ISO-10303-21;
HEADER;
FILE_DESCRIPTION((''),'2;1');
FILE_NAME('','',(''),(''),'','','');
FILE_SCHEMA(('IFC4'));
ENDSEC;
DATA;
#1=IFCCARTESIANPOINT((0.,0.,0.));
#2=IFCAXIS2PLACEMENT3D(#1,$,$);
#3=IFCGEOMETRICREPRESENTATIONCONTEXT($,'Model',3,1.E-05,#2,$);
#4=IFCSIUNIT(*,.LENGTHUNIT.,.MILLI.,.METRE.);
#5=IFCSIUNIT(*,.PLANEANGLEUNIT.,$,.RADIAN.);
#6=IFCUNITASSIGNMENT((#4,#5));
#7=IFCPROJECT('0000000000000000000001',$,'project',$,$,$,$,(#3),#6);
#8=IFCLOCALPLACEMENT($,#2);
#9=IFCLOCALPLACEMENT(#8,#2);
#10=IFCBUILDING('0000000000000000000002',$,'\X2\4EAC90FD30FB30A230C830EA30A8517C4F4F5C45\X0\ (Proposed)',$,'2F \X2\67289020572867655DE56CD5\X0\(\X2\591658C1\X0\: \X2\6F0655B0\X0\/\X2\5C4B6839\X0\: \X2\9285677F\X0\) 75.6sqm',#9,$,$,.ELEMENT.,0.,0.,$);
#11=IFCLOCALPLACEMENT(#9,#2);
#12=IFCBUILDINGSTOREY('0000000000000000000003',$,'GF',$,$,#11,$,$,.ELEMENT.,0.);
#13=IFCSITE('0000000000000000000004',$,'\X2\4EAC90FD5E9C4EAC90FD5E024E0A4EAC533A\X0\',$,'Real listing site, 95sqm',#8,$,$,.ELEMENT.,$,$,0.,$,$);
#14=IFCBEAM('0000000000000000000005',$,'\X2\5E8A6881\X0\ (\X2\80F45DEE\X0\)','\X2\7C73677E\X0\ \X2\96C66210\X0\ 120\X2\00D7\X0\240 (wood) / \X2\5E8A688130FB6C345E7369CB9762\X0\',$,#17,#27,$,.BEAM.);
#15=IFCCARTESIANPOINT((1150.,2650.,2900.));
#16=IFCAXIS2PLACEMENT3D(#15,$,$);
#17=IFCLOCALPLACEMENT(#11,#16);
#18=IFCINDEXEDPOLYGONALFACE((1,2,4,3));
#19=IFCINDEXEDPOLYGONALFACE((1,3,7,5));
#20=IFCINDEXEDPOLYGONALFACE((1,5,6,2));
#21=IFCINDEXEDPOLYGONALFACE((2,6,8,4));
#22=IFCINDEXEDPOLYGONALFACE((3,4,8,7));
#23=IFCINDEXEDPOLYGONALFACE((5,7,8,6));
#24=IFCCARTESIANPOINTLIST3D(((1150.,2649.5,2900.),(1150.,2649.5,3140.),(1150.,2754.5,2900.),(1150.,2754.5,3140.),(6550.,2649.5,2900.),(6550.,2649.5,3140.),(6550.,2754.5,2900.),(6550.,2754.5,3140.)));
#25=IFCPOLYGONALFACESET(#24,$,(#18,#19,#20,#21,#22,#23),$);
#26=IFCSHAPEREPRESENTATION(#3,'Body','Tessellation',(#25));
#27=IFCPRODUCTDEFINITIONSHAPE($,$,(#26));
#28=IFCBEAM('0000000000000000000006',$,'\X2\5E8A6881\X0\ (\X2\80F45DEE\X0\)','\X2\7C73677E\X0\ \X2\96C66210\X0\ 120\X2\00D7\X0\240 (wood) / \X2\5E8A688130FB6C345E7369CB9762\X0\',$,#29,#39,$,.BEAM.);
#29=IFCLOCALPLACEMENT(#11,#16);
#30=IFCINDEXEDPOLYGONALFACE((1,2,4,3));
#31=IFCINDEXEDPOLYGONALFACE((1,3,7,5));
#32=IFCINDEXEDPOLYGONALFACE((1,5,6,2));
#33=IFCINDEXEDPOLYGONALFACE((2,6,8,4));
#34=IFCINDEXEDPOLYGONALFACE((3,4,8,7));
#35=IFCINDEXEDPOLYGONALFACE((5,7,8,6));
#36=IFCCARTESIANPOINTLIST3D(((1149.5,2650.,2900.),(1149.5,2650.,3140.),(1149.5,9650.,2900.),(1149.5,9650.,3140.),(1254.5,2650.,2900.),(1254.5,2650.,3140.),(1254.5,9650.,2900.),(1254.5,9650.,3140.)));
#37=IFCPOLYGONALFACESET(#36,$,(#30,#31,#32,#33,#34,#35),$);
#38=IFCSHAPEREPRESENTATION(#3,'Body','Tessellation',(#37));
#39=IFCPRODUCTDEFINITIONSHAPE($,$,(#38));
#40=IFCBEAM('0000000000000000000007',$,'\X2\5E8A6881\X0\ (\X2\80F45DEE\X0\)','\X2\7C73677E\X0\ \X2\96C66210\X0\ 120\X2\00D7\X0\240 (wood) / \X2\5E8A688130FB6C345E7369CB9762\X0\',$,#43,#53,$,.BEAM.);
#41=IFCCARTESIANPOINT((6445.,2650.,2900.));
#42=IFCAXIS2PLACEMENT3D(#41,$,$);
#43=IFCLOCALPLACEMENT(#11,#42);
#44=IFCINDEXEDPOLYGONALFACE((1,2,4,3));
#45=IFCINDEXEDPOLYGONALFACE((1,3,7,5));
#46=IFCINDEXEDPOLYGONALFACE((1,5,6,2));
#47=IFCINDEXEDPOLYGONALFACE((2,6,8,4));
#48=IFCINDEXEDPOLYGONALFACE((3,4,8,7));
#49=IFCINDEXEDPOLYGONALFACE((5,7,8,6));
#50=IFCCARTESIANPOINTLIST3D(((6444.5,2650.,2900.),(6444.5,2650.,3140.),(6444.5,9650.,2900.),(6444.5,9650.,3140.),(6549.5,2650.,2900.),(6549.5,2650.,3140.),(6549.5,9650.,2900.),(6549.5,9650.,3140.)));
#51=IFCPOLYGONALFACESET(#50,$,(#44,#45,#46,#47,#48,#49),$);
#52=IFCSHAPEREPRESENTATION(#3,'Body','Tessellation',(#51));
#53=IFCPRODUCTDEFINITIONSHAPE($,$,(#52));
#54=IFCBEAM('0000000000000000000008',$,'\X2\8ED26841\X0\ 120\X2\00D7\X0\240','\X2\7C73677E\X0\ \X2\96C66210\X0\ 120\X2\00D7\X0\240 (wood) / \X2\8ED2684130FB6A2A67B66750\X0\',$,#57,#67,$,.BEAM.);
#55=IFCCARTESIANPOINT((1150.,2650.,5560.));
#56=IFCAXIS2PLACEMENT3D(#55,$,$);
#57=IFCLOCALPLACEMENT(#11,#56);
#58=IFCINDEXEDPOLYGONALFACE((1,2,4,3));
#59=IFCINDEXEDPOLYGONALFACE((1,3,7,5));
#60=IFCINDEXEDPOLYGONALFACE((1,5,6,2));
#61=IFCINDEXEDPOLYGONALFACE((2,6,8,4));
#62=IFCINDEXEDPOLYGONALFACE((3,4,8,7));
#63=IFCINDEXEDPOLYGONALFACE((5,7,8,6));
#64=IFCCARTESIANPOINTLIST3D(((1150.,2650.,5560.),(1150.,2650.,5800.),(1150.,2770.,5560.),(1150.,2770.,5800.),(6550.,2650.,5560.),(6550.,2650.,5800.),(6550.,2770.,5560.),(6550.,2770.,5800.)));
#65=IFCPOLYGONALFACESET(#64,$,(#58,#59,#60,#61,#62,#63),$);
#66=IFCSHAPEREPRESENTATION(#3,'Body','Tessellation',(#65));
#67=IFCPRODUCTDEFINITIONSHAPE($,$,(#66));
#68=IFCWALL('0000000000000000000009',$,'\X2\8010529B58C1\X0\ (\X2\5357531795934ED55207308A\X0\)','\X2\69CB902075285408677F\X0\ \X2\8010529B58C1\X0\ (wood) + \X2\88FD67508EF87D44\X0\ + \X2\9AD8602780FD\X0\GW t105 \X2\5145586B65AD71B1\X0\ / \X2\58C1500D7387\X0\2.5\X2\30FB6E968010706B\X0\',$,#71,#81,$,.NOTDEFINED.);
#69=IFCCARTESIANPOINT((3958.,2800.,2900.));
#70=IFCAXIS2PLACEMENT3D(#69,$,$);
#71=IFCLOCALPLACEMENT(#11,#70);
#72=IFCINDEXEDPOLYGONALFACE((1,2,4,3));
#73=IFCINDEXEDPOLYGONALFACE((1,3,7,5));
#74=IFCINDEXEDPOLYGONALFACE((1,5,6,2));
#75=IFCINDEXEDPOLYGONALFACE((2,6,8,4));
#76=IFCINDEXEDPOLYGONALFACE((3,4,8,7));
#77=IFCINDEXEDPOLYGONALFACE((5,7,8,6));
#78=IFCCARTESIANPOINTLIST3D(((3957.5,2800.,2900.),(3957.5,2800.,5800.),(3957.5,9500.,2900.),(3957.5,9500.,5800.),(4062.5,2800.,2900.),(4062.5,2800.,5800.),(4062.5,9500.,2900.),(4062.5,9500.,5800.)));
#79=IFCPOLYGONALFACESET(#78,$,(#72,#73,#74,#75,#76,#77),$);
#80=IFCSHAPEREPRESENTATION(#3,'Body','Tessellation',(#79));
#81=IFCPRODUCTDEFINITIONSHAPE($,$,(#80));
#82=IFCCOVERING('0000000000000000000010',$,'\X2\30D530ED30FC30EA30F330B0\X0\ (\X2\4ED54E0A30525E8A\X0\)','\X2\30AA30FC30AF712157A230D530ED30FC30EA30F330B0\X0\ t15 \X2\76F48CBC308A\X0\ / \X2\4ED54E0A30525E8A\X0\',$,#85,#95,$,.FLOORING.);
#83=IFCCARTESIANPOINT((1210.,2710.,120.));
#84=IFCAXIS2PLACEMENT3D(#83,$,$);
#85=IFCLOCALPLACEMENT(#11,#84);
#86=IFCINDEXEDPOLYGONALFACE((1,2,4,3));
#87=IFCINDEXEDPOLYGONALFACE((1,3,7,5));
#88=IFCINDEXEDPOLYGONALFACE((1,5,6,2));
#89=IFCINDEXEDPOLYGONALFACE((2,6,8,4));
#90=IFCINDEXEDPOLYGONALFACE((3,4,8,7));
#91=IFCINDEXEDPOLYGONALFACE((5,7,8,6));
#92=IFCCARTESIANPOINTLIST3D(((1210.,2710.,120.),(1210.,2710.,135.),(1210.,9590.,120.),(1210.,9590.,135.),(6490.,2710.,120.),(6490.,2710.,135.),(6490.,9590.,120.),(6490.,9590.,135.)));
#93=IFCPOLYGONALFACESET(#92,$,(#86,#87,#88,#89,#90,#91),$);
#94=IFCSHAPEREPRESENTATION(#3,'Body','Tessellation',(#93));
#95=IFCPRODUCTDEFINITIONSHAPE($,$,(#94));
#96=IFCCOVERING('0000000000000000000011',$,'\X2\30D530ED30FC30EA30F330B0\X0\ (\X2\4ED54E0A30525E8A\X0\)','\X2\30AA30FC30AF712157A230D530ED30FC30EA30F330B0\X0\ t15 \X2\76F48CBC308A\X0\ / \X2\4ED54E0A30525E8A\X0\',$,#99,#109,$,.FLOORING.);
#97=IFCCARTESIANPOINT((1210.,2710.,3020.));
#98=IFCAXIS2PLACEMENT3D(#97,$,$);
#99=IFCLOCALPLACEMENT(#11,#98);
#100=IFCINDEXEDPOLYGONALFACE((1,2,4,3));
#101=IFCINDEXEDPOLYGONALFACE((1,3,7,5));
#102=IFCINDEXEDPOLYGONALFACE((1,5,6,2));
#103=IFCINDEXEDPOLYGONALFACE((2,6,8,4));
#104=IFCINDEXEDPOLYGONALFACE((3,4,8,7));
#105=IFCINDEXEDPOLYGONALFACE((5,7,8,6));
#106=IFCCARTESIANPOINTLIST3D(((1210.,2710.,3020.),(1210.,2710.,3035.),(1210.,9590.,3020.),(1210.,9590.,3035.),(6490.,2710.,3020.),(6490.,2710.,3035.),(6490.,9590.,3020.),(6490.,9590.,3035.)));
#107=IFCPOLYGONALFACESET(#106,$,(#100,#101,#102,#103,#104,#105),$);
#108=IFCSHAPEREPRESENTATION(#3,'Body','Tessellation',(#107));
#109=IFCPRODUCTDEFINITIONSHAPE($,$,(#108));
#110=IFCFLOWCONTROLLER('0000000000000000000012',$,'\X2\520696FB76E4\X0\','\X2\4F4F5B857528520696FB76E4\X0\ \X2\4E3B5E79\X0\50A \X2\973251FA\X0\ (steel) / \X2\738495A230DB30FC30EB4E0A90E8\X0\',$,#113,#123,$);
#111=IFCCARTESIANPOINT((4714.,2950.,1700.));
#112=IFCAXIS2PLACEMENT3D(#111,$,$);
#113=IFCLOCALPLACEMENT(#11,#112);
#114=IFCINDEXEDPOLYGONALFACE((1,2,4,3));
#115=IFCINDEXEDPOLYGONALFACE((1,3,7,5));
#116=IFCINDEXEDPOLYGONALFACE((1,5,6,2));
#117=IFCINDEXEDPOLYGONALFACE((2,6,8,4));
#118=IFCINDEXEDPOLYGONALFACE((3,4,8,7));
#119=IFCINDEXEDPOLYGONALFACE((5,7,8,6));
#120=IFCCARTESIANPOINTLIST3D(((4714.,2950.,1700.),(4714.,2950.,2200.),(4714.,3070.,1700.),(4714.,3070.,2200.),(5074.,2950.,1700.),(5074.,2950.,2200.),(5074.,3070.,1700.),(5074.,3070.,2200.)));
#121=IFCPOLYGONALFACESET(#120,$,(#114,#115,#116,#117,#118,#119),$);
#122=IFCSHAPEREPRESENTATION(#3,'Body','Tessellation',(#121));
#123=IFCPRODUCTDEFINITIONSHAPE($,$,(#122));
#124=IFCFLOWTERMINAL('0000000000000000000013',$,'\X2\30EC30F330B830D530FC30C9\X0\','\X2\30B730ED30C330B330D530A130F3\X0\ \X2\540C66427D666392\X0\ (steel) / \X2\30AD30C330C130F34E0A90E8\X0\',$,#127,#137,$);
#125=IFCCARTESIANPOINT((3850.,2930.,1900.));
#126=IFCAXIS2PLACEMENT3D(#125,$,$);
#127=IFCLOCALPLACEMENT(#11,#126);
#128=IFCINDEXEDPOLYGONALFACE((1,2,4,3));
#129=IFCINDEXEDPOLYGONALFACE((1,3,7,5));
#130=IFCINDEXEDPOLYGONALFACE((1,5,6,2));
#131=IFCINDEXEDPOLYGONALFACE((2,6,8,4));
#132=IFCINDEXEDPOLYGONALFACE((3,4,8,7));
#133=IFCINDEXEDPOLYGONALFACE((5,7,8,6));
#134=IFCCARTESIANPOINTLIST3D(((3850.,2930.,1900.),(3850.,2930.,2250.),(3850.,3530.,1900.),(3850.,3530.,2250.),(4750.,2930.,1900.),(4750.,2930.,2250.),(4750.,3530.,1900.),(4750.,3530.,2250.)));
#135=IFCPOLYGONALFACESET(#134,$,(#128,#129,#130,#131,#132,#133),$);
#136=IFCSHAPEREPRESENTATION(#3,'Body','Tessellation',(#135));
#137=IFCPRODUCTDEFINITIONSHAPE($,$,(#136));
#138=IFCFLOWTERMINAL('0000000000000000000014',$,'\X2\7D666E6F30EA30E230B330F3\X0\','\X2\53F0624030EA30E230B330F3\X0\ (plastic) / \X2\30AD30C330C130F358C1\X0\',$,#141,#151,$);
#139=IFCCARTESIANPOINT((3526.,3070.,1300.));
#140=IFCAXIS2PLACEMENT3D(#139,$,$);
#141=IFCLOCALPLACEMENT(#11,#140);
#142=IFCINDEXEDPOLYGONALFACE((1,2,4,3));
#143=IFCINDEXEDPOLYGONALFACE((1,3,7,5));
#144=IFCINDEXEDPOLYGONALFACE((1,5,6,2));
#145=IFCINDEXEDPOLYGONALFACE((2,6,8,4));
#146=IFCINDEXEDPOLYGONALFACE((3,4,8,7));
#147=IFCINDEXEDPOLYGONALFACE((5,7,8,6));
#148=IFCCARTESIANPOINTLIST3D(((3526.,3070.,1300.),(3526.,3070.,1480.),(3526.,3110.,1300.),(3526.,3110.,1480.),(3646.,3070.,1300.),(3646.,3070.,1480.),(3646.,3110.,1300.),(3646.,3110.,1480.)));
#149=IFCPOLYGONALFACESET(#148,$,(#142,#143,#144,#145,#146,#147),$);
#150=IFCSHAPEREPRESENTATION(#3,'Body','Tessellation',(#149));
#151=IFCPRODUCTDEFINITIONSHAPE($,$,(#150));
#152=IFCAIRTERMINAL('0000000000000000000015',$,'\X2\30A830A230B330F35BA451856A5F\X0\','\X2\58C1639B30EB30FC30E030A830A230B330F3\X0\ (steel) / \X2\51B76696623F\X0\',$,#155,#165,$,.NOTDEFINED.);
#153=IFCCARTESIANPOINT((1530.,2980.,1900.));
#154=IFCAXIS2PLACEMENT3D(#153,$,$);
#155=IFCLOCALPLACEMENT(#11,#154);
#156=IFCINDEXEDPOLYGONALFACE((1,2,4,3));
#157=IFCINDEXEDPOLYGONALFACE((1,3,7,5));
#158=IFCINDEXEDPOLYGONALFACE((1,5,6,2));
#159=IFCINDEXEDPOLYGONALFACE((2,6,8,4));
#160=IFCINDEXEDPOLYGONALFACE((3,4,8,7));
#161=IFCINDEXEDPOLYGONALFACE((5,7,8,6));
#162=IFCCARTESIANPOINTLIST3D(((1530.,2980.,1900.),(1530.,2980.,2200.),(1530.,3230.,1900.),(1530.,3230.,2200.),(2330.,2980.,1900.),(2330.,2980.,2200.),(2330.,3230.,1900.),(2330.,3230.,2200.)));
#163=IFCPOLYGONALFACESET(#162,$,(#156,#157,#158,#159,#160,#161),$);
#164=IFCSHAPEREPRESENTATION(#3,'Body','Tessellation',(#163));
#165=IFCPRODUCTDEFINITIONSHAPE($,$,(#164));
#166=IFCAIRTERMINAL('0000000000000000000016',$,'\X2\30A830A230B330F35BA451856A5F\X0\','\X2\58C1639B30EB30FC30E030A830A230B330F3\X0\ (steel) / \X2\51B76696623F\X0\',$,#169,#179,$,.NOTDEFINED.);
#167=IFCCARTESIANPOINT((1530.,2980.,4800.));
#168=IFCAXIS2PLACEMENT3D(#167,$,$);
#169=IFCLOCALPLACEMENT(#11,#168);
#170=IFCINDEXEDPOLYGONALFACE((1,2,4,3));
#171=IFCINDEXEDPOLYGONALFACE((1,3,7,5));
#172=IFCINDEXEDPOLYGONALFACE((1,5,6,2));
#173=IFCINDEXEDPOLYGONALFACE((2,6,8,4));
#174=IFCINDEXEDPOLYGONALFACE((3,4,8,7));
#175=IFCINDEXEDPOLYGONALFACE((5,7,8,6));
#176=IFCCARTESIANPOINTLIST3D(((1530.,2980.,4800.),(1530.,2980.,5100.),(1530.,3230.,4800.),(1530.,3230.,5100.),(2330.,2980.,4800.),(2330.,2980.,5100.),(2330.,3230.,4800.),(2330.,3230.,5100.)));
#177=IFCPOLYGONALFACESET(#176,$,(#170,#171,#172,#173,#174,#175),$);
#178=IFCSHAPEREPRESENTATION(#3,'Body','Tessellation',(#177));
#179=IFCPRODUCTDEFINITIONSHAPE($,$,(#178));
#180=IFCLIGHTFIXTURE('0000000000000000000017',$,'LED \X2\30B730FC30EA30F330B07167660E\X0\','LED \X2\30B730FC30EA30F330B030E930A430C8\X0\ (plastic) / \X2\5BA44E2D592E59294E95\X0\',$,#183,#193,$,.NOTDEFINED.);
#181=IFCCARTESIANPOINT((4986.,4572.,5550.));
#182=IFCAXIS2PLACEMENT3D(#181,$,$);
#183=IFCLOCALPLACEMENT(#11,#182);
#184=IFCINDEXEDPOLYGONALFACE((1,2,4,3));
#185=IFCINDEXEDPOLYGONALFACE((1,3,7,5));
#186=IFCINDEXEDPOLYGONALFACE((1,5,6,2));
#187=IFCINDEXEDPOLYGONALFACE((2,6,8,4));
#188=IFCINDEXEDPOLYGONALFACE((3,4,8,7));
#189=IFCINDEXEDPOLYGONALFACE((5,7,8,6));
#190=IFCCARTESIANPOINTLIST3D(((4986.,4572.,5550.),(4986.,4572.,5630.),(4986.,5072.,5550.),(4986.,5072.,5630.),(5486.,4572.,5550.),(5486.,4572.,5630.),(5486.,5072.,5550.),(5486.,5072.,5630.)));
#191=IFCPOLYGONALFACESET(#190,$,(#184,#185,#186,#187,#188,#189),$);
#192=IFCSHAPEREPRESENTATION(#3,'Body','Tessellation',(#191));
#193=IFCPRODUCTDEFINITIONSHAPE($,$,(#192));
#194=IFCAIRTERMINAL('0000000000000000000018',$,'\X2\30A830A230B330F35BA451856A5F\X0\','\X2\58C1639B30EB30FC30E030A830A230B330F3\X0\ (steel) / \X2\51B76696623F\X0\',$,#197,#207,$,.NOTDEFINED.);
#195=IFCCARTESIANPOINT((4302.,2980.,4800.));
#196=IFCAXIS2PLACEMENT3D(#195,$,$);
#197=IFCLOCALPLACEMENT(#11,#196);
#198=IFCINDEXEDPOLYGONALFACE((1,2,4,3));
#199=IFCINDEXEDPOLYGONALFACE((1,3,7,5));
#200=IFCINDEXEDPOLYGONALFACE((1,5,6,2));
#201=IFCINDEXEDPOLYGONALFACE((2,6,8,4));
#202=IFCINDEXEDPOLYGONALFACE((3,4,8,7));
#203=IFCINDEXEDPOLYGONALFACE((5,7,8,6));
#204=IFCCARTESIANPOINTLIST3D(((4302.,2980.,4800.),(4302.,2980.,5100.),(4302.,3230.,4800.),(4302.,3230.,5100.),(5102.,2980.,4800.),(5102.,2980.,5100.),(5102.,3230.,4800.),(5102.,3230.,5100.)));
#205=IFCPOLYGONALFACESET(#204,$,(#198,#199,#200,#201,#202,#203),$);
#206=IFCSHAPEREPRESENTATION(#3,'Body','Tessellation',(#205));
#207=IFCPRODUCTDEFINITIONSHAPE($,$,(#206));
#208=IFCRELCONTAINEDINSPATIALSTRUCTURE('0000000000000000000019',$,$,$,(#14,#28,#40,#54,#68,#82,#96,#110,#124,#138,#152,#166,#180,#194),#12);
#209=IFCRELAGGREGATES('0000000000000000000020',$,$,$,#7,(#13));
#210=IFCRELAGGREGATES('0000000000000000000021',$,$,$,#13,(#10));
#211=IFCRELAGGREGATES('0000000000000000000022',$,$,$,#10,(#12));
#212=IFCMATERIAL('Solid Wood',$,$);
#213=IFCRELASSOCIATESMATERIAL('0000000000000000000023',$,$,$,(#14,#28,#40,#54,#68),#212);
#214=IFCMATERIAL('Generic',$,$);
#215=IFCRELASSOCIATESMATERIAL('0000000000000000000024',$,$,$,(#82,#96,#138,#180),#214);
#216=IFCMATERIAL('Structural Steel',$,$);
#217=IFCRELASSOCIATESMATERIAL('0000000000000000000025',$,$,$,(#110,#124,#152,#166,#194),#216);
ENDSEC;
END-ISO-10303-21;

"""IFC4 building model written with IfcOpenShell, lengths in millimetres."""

from ifc_helpers import new_model, si_unit, frame, frame_2d, origin, place, context, project, spatial, rectangle, extrude, material, element, save


model = new_model("IFC4")

# Units and contexts
model_context = context("Model", 3, precision=1e-05, world=origin())
ifc_project = project(units=[si_unit("LENGTHUNIT", "METRE", prefix="MILLI"), si_unit("PLANEANGLEUNIT", "RADIAN")], contexts=[model_context])

# Site, building, storey
site_placement = place(None, origin())
site = spatial("IfcSite", under=ifc_project, at=site_placement, Name="京都府京都市上京区", ObjectType="Real listing site, 95sqm", CompositionType="ELEMENT", RefElevation=0.0)
building_placement = place(site_placement, origin())
building = spatial("IfcBuilding", under=site, at=building_placement, Name="京都・アトリエ兼住居 (Proposed)", ObjectType="2F 木造在来工法(外壁: 漆喰/屋根: 銅板) 75.6sqm", CompositionType="ELEMENT", ElevationOfRefHeight=0.0, ElevationOfTerrain=0.0)
storey_placement = place(building_placement, origin())
storey = spatial("IfcBuildingStorey", under=building, at=storey_placement, Name="GF", CompositionType="ELEMENT", Elevation=0.0)

# Shared definitions
ifc_material_1 = material(Name="Solid Wood")

# Beams
beam_1_placement = place(storey_placement, frame((1150.0, 2650.0, 2900.0)))
element("IfcBeam", 1, at=beam_1_placement, inside=storey, material=ifc_material_1, Name="床梁 (胴差)", Description="米松 集成 120×240 (wood) / 床梁・水平構面", PredefinedType="BEAM", context=model_context, shape_type="SweptSolid", body=[
    extrude(rectangle(XDim=5400.0, YDim=105.0, at=frame_2d((2700.0, 52.0))), frame((1150.0, 2650.0, 2900.0)), (0.0, 0.0, 1.0), 240.0),
])
beam_2_placement = place(storey_placement, frame((1150.0, 2650.0, 2900.0)))
element("IfcBeam", 2, at=beam_2_placement, inside=storey, material=ifc_material_1, Name="床梁 (胴差)", Description="米松 集成 120×240 (wood) / 床梁・水平構面", PredefinedType="BEAM", context=model_context, shape_type="SweptSolid", body=[
    extrude(rectangle(XDim=105.0, YDim=7000.0, at=frame_2d((52.0, 3500.0))), frame((1150.0, 2650.0, 2900.0)), (0.0, 0.0, 1.0), 240.0),
])
beam_3_placement = place(storey_placement, frame((6445.0, 2650.0, 2900.0)))
element("IfcBeam", 3, at=beam_3_placement, inside=storey, material=ifc_material_1, Name="床梁 (胴差)", Description="米松 集成 120×240 (wood) / 床梁・水平構面", PredefinedType="BEAM", context=model_context, shape_type="SweptSolid", body=[
    extrude(rectangle(XDim=105.0, YDim=7000.0, at=frame_2d((52.0, 3500.0))), frame((6445.0, 2650.0, 2900.0)), (0.0, 0.0, 1.0), 240.0),
])
beam_4_placement = place(storey_placement, frame((1150.0, 2650.0, 5560.0)))
element("IfcBeam", 4, at=beam_4_placement, inside=storey, material=ifc_material_1, Name="軒桁 120×240", Description="米松 集成 120×240 (wood) / 軒桁・横架材", PredefinedType="BEAM", context=model_context, shape_type="SweptSolid", body=[
    extrude(rectangle(XDim=5400.0, YDim=120.0, at=frame_2d((2700.0, 60.0))), frame((1150.0, 2650.0, 5560.0)), (0.0, 0.0, 1.0), 240.0),
])

# Wall
wall_1_placement = place(storey_placement, frame((3958.0, 2800.0, 2900.0)))
element("IfcWall", 5, at=wall_1_placement, inside=storey, material=ifc_material_1, Name="耐力壁 (南北間仕切り)", Description="構造用合板 耐力壁 (wood) + 製材軸組 + 高性能GW t105 充填断熱 / 壁倍率2.5・準耐火", PredefinedType="NOTDEFINED", context=model_context, shape_type="SweptSolid", body=[
    extrude(rectangle(XDim=105.0, YDim=6700.0, at=frame_2d((52.0, 3350.0))), frame((3958.0, 2800.0, 2900.0)), (0.0, 0.0, 1.0), 2900.0),
])

# Coverings
ifc_material_2 = material(Name="Generic")
covering_1_placement = place(storey_placement, frame((1210.0, 2710.0, 120.0)))
element("IfcCovering", 6, at=covering_1_placement, inside=storey, material=ifc_material_2, Name="フローリング (仕上げ床)", Description="オーク無垢フローリング t15 直貼り / 仕上げ床", PredefinedType="FLOORING", context=model_context, shape_type="SweptSolid", body=[
    extrude(rectangle(XDim=5280.0, YDim=6880.0, at=frame_2d((2640.0, 3440.0))), frame((1210.0, 2710.0, 120.0)), (0.0, 0.0, 1.0), 15.0),
])
covering_2_placement = place(storey_placement, frame((1210.0, 2710.0, 3020.0)))
element("IfcCovering", 7, at=covering_2_placement, inside=storey, material=ifc_material_2, Name="フローリング (仕上げ床)", Description="オーク無垢フローリング t15 直貼り / 仕上げ床", PredefinedType="FLOORING", context=model_context, shape_type="SweptSolid", body=[
    extrude(rectangle(XDim=5280.0, YDim=6880.0, at=frame_2d((2640.0, 3440.0))), frame((1210.0, 2710.0, 3020.0)), (0.0, 0.0, 1.0), 15.0),
])

# Flow controller
ifc_material_3 = material(Name="Structural Steel")
flow_controller_placement = place(storey_placement, frame((4714.0, 2950.0, 1700.0)))
element("IfcFlowController", 8, at=flow_controller_placement, inside=storey, material=ifc_material_3, Name="分電盤", Description="住宅用分電盤 主幹50A 露出 (steel) / 玄関ホール上部", context=model_context, shape_type="SweptSolid", body=[
    extrude(rectangle(XDim=360.0, YDim=120.0, at=frame_2d((180.0, 60.0))), frame((4714.0, 2950.0, 1700.0)), (0.0, 0.0, 1.0), 500.0),
])

# Flow terminals
flow_terminal_1_placement = place(storey_placement, frame((3850.0, 2930.0, 1900.0)))
element("IfcFlowTerminal", 9, at=flow_terminal_1_placement, inside=storey, material=ifc_material_3, Name="レンジフード", Description="シロッコファン 同時給排 (steel) / キッチン上部", context=model_context, shape_type="SweptSolid", body=[
    extrude(rectangle(XDim=900.0, YDim=600.0, at=frame_2d((450.0, 300.0))), frame((3850.0, 2930.0, 1900.0)), (0.0, 0.0, 1.0), 350.0),
])
flow_terminal_2_placement = place(storey_placement, frame((3526.0, 3070.0, 1300.0)))
element("IfcFlowTerminal", 10, at=flow_terminal_2_placement, inside=storey, material=ifc_material_2, Name="給湯リモコン", Description="台所リモコン (plastic) / キッチン壁", context=model_context, shape_type="SweptSolid", body=[
    extrude(rectangle(XDim=120.0, YDim=40.0, at=frame_2d((60.0, 20.0))), frame((3526.0, 3070.0, 1300.0)), (0.0, 0.0, 1.0), 180.0),
])

# Air terminals
air_terminal_1_placement = place(storey_placement, frame((1530.0, 2980.0, 1900.0)))
element("IfcAirTerminal", 11, at=air_terminal_1_placement, inside=storey, material=ifc_material_3, Name="エアコン室内機", Description="壁掛ルームエアコン (steel) / 冷暖房", PredefinedType="NOTDEFINED", context=model_context, shape_type="SweptSolid", body=[
    extrude(rectangle(XDim=800.0, YDim=250.0, at=frame_2d((400.0, 125.0))), frame((1530.0, 2980.0, 1900.0)), (0.0, 0.0, 1.0), 300.0),
])
air_terminal_2_placement = place(storey_placement, frame((1530.0, 2980.0, 4800.0)))
element("IfcAirTerminal", 12, at=air_terminal_2_placement, inside=storey, material=ifc_material_3, Name="エアコン室内機", Description="壁掛ルームエアコン (steel) / 冷暖房", PredefinedType="NOTDEFINED", context=model_context, shape_type="SweptSolid", body=[
    extrude(rectangle(XDim=800.0, YDim=250.0, at=frame_2d((400.0, 125.0))), frame((1530.0, 2980.0, 4800.0)), (0.0, 0.0, 1.0), 300.0),
])

# Light fixture
light_fixture_placement = place(storey_placement, frame((4986.0, 4572.0, 5550.0)))
element("IfcLightFixture", 13, at=light_fixture_placement, inside=storey, material=ifc_material_2, Name="LED シーリング照明", Description="LED シーリングライト (plastic) / 室中央天井", PredefinedType="NOTDEFINED", context=model_context, shape_type="SweptSolid", body=[
    extrude(rectangle(XDim=500.0, YDim=500.0, at=frame_2d((250.0, 250.0))), frame((4986.0, 4572.0, 5550.0)), (0.0, 0.0, 1.0), 80.0),
])

# Air terminal
air_terminal_3_placement = place(storey_placement, frame((4302.0, 2980.0, 4800.0)))
element("IfcAirTerminal", 14, at=air_terminal_3_placement, inside=storey, material=ifc_material_3, Name="エアコン室内機", Description="壁掛ルームエアコン (steel) / 冷暖房", PredefinedType="NOTDEFINED", context=model_context, shape_type="SweptSolid", body=[
    extrude(rectangle(XDim=800.0, YDim=250.0, at=frame_2d((400.0, 125.0))), frame((4302.0, 2980.0, 4800.0)), (0.0, 0.0, 1.0), 300.0),
])

save(model, "model.ifc")
